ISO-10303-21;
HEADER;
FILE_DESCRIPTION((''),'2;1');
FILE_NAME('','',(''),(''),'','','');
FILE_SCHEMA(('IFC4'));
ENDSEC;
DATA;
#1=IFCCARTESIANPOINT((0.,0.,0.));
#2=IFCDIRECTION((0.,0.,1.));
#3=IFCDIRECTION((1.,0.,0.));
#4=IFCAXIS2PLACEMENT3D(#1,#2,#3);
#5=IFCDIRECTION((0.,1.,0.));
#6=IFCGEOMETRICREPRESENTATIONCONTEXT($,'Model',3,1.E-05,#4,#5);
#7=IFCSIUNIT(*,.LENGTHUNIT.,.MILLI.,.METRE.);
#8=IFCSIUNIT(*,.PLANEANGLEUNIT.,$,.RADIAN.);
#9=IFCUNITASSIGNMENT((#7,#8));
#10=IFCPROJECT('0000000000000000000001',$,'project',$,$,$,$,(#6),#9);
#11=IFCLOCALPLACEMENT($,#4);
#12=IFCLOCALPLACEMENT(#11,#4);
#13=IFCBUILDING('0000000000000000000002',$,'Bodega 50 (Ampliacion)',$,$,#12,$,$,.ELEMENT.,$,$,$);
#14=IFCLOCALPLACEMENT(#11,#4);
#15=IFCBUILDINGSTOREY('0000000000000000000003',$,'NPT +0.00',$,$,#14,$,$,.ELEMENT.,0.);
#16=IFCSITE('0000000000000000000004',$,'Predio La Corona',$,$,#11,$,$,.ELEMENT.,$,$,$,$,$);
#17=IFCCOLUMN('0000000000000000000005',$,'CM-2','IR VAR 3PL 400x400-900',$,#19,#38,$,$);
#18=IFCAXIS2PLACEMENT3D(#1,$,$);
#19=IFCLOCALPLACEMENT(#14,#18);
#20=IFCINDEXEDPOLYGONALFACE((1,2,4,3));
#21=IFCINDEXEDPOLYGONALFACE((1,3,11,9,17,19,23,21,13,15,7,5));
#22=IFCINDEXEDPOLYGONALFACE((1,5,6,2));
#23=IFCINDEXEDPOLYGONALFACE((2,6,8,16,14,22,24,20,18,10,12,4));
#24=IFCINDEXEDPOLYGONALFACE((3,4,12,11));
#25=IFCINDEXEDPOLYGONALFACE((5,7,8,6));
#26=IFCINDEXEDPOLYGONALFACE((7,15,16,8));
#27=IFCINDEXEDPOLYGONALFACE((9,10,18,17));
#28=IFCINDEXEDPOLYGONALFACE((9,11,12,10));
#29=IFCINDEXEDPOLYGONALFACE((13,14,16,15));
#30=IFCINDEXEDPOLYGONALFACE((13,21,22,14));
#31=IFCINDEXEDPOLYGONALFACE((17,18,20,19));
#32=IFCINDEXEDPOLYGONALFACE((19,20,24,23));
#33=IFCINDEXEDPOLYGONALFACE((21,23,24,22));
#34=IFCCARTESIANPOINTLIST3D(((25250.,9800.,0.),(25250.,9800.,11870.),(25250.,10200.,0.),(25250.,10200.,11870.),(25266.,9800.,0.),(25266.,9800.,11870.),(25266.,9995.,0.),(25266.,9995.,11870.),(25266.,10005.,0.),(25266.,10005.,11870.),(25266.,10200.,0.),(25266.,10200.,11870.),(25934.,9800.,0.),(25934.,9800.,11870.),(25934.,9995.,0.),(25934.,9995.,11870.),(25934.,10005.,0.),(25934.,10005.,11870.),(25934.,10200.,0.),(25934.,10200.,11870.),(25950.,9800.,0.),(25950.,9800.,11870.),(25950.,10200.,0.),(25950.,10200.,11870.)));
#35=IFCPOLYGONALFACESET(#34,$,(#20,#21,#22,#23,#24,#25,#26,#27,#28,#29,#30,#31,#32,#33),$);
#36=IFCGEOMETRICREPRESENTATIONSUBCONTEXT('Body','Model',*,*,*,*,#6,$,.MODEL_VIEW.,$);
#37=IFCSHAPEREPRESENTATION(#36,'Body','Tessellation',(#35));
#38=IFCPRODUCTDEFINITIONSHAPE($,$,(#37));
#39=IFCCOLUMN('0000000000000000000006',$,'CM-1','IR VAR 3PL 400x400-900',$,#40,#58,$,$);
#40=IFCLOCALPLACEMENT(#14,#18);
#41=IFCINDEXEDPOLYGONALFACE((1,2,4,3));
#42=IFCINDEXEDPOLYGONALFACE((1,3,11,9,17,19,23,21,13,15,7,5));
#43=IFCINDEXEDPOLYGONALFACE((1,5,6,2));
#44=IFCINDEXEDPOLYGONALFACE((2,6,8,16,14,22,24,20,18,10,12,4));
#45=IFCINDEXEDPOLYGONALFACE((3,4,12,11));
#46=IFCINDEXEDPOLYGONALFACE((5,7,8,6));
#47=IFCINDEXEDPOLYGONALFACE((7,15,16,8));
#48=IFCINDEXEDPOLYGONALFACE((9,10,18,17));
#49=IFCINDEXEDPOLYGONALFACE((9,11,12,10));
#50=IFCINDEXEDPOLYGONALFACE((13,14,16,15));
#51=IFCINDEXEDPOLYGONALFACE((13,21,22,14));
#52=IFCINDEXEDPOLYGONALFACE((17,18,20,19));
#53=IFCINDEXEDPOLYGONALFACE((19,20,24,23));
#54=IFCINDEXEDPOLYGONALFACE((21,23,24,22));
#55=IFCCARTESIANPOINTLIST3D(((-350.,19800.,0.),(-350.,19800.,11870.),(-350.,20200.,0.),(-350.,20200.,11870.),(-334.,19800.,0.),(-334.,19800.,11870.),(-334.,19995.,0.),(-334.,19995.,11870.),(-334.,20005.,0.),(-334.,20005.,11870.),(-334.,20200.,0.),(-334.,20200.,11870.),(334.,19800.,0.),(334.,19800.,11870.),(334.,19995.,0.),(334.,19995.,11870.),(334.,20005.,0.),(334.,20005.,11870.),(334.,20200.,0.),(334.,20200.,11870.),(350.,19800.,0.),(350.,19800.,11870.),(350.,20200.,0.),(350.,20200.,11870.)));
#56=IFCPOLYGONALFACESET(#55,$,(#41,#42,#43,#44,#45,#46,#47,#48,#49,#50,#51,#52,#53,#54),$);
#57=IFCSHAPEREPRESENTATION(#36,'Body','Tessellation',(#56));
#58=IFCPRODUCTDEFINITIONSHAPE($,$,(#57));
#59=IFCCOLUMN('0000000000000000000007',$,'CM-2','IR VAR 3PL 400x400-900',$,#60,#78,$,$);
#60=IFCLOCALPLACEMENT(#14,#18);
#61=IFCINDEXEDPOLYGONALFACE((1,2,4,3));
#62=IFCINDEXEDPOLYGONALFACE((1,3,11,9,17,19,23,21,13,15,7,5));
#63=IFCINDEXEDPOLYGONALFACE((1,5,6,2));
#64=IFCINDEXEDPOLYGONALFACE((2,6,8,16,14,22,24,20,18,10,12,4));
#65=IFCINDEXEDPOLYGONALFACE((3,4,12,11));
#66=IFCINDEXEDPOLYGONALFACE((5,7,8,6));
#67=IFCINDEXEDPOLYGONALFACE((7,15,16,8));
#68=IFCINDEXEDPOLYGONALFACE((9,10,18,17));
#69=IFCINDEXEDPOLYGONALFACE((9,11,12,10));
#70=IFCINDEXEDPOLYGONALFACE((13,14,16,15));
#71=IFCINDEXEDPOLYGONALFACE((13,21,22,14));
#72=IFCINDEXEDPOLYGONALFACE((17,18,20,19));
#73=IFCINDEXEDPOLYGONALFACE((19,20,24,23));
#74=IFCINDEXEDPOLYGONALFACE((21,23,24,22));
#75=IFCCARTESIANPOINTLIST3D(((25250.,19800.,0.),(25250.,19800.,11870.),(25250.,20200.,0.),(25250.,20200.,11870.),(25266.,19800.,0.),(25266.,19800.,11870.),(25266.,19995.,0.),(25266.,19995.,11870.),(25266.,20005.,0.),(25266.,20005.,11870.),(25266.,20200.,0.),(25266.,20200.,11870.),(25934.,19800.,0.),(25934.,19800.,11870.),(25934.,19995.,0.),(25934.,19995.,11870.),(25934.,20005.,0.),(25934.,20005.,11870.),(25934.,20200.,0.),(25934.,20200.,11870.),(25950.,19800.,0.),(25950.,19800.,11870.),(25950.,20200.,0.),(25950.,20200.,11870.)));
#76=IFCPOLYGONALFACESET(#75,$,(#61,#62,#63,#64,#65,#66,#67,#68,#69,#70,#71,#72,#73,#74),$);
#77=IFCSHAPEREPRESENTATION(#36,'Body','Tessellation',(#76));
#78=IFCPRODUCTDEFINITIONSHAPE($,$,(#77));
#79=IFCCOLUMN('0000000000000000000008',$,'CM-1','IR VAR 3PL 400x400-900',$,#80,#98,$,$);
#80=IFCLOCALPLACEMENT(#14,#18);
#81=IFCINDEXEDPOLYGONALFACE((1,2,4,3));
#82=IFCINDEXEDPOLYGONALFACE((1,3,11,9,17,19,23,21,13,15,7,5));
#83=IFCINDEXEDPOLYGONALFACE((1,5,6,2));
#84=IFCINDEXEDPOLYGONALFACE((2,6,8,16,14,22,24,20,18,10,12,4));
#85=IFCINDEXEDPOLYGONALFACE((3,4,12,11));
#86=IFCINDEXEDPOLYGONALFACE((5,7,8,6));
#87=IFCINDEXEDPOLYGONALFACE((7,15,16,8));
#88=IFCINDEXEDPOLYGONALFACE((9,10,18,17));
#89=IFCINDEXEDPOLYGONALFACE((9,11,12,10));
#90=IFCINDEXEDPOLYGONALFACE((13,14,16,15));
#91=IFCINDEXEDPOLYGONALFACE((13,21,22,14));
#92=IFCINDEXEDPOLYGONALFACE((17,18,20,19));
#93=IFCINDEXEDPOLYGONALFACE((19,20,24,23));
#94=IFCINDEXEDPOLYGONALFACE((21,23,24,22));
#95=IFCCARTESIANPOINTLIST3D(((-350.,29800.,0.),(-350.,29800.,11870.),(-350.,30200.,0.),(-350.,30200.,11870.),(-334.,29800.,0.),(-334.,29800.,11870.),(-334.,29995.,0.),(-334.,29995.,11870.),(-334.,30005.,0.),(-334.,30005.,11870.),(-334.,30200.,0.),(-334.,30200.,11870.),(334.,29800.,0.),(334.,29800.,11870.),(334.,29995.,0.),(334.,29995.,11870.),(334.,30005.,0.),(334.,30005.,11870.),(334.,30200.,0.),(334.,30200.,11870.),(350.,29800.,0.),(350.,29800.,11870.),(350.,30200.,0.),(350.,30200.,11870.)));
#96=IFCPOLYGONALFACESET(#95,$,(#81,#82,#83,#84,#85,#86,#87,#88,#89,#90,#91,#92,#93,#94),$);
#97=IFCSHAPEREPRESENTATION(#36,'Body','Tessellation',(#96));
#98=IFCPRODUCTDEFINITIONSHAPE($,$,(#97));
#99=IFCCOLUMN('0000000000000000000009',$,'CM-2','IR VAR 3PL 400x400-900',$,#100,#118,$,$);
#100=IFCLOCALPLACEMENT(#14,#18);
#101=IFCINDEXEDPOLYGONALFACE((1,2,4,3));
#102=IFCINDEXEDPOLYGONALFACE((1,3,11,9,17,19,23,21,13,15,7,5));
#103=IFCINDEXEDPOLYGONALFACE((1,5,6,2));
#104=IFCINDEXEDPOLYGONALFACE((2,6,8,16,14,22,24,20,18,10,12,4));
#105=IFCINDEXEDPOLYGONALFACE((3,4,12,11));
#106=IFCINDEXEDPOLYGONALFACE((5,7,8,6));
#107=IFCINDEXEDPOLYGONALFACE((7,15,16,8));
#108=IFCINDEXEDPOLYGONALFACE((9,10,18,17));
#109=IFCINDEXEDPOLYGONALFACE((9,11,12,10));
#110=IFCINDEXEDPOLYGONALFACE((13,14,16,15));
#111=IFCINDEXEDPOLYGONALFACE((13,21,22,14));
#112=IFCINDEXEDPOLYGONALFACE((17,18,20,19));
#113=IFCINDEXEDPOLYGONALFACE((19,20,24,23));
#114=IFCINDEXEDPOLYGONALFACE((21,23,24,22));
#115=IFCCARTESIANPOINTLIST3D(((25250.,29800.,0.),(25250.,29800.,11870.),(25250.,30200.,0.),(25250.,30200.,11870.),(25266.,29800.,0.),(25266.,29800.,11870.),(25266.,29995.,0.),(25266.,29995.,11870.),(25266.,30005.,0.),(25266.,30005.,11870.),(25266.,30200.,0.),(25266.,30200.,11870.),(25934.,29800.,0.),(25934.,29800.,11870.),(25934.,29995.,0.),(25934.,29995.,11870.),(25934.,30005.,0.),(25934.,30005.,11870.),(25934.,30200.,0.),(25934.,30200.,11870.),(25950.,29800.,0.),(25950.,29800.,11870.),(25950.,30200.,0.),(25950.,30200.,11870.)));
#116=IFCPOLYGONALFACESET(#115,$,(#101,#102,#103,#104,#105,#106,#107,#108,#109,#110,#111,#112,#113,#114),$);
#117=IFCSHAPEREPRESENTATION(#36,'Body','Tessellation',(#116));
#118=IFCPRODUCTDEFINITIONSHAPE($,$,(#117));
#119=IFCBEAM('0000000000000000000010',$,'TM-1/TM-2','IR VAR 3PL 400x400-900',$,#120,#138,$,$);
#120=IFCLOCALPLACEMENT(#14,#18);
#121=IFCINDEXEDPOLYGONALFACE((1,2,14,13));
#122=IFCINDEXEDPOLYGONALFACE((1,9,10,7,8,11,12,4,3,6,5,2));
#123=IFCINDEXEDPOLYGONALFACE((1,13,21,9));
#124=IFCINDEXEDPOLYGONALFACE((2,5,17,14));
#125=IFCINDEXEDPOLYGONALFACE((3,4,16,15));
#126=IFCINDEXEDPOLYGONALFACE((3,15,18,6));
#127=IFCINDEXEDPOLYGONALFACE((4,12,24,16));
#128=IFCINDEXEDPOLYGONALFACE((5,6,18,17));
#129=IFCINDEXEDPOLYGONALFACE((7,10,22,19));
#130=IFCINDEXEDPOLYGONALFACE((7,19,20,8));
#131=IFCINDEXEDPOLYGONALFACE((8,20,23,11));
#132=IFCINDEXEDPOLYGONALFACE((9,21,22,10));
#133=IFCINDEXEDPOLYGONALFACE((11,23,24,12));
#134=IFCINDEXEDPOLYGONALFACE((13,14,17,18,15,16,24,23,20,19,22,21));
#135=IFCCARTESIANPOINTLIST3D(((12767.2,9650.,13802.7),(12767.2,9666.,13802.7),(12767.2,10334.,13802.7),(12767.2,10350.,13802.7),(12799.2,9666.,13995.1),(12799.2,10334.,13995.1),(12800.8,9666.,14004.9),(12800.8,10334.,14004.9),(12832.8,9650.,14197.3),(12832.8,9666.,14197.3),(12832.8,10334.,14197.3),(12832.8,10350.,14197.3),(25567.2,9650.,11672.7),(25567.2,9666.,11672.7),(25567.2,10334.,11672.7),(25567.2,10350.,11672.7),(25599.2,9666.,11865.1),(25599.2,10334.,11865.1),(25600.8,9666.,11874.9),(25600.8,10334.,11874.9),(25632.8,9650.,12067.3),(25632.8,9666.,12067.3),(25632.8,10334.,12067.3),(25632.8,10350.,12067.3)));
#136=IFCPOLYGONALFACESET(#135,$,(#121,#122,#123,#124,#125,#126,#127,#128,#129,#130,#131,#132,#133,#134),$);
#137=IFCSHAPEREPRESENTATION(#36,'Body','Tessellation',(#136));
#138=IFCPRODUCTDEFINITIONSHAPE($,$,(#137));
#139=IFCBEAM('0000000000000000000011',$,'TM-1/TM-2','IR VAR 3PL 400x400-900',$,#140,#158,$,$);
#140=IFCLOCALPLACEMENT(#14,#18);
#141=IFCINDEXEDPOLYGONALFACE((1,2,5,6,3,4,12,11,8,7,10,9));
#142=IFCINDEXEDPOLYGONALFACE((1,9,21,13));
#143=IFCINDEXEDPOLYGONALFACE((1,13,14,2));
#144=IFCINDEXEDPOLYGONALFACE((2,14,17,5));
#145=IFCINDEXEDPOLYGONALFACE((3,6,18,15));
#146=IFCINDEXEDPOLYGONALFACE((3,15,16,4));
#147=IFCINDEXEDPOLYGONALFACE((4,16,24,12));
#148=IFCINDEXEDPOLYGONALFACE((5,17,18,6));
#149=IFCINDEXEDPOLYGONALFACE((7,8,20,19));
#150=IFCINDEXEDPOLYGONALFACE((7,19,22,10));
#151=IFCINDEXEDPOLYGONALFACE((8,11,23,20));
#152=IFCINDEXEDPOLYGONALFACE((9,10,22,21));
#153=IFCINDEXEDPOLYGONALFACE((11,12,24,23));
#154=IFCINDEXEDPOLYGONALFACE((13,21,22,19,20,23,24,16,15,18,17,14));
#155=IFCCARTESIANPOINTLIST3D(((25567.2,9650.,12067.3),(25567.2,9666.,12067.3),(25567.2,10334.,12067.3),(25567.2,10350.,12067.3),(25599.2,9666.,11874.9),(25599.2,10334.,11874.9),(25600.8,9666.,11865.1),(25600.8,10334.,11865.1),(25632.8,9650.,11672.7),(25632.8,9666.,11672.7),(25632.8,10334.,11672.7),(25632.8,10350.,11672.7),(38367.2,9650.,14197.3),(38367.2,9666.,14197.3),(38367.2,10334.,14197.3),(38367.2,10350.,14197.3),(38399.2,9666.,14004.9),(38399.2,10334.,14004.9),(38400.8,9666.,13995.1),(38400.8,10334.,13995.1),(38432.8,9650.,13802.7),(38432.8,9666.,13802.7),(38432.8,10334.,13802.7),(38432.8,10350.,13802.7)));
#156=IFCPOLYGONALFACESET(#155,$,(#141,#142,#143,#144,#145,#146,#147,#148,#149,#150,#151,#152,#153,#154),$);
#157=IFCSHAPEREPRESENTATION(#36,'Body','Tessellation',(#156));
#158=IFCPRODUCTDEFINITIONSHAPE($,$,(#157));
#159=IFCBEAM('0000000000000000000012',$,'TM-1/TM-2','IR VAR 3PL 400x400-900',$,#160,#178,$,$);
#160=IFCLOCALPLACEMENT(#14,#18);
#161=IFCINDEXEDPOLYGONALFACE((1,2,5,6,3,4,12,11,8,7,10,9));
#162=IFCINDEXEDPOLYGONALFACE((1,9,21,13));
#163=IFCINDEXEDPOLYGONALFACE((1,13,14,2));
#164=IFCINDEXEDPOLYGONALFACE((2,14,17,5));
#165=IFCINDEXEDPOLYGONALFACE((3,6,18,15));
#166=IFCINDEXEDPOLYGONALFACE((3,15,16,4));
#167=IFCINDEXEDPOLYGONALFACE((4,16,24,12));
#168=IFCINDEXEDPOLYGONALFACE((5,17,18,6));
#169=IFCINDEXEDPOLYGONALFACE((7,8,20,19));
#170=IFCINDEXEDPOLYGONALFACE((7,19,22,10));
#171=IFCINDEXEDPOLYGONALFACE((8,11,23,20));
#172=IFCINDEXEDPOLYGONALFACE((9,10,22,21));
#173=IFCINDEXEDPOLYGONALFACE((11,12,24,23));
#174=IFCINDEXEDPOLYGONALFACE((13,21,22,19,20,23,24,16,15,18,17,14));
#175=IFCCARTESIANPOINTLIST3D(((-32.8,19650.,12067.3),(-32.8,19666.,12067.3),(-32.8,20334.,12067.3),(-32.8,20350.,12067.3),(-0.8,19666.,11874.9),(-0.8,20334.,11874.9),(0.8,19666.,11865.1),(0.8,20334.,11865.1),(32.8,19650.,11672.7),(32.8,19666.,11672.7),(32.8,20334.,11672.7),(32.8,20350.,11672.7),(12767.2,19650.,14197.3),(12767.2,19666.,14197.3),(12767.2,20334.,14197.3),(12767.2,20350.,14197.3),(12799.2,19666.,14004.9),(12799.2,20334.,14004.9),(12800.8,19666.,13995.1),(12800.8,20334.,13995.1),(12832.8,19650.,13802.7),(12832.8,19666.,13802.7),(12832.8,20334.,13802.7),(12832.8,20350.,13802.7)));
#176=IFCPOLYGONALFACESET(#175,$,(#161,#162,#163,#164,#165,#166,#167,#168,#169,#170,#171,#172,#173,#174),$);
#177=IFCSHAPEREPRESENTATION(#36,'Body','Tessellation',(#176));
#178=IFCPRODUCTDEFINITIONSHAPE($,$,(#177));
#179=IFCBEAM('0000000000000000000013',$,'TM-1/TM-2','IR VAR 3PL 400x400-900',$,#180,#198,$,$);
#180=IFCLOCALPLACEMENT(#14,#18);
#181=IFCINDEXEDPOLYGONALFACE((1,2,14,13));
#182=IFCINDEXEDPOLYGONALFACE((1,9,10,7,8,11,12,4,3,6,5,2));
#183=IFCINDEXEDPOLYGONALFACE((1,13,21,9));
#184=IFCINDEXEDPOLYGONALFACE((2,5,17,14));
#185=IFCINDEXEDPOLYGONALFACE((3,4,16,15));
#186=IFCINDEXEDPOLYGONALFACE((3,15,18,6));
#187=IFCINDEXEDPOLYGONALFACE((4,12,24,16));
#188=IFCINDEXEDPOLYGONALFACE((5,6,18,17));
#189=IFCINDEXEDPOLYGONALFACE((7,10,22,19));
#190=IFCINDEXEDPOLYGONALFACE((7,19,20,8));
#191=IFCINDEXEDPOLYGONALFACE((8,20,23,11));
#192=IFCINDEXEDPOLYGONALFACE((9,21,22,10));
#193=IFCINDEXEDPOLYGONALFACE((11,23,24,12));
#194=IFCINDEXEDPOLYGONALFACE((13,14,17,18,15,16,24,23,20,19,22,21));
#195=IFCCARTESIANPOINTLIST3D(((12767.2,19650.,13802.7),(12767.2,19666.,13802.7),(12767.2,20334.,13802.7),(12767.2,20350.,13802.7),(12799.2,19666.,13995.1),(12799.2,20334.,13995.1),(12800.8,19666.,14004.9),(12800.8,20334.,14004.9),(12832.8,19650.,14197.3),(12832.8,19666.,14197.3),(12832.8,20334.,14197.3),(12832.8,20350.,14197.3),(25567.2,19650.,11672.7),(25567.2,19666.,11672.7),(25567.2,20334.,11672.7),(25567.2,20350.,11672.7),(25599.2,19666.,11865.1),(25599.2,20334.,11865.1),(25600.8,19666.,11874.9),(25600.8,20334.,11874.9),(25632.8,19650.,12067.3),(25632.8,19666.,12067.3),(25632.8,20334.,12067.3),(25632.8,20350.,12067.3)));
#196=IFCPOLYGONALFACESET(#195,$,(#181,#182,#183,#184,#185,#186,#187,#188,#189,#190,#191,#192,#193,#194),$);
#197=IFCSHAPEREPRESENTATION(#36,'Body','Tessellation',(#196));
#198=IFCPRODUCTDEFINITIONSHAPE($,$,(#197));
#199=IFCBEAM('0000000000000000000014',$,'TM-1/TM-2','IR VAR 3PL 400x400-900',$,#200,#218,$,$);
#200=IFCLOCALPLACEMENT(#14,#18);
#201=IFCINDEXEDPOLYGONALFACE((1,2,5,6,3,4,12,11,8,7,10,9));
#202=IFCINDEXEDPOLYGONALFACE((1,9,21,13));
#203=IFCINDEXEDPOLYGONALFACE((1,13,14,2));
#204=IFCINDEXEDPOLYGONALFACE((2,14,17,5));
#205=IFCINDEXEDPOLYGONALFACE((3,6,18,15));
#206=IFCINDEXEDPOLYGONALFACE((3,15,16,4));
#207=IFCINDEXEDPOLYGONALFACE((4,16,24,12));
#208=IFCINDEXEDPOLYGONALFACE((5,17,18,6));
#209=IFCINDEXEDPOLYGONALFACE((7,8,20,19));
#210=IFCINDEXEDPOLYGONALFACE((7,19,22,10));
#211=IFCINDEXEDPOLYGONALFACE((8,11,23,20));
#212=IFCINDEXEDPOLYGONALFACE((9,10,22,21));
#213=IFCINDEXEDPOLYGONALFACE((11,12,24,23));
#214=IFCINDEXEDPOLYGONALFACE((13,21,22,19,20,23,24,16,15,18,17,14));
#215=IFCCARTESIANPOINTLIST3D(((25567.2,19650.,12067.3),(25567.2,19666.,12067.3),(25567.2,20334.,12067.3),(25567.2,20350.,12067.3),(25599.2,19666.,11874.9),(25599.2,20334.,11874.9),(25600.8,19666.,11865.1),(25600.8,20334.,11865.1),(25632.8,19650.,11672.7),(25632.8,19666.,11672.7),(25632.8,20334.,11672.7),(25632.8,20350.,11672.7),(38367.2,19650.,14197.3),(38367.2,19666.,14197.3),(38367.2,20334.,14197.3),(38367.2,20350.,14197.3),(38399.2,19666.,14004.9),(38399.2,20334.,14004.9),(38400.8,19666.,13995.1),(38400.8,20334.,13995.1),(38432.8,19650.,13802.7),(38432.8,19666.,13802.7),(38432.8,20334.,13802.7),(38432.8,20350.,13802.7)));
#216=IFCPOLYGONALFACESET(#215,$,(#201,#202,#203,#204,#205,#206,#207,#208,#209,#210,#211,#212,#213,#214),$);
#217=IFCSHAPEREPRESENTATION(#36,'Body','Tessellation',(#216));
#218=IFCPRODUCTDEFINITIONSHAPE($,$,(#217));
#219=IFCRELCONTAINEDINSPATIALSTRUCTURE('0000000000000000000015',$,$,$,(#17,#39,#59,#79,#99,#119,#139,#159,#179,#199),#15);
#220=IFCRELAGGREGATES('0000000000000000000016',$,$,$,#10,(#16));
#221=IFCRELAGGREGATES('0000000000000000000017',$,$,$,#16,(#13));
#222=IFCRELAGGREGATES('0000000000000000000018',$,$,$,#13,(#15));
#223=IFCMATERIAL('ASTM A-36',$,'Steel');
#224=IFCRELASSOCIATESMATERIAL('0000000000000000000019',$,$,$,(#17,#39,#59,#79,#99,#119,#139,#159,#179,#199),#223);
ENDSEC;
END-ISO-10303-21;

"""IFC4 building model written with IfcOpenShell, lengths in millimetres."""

from ifc_helpers import new_model, si_unit, direction, frame, origin_with_axes, origin_2d, place, context, subcontext, project, spatial, i_section, extrude, material, element, save


model = new_model("IFC4")

# Units and contexts
model_context = context("Model", 3, precision=1e-05, world=origin_with_axes(), true_north=direction((0.0, 1.0, 0.0)))
body_context = subcontext(model_context, "Body", "Model", "MODEL_VIEW")
ifc_project = project(units=[si_unit("LENGTHUNIT", "METRE", prefix="MILLI"), si_unit("PLANEANGLEUNIT", "RADIAN")], contexts=[model_context])

# Site, building, storey
site_placement = place(None, origin_with_axes())
site = spatial("IfcSite", under=ifc_project, at=site_placement, Name="Predio La Corona", CompositionType="ELEMENT")
building_placement = place(site_placement, origin_with_axes())
building = spatial("IfcBuilding", under=site, at=building_placement, Name="Bodega 50 (Ampliacion)", CompositionType="ELEMENT")
storey_placement = place(site_placement, origin_with_axes())
storey = spatial("IfcBuildingStorey", under=building, at=storey_placement, Name="NPT +0.00", CompositionType="ELEMENT", Elevation=0.0)

# Columns
ifc_material = material(Name="ASTM A-36", Category="Steel")
for number, where, z_axis, x_axis, name in (
    (1, (25600.0, 10000.0, 0.0), (0.0, 0.0, 1.0), (0.0, -1.0, 0.0), "CM-2"),
    (2, (0.0, 20000.0, 0.0), (0.0, 0.0, 1.0), (0.0, -1.0, 0.0), "CM-1"),
    (3, (25600.0, 20000.0, 0.0), (0.0, 0.0, 1.0), (0.0, -1.0, 0.0), "CM-2"),
    (4, (0.0, 30000.0, 0.0), (0.0, 0.0, 1.0), (0.0, -1.0, 0.0), "CM-1"),
    (5, (25600.0, 30000.0, 0.0), (0.0, 0.0, 1.0), (0.0, -1.0, 0.0), "CM-2"),
):
    element("IfcColumn", number, at=place(storey_placement, frame(where, z_axis=z_axis, x_axis=x_axis)), inside=storey, material=ifc_material, Name=name, Description="IR VAR 3PL 400x400-900", context=body_context, shape_type="SweptSolid", body=[
        extrude(i_section(OverallWidth=400.0, OverallDepth=700.0, WebThickness=10.0, FlangeThickness=16.0, at=origin_2d()), origin_with_axes(), (0.0, 0.0, 1.0), 11870.0),
    ])

# Beams
for number, where, z_axis, x_axis, name in (
    (6, (12800.0, 10000.0, 14000.0), (0.986436, 0.0, -0.164149), (-0.164149, 0.0, -0.986436), "TM-1/TM-2"),
    (7, (25600.0, 10000.0, 11870.0), (0.986436, 0.0, 0.164149), (0.164149, 0.0, -0.986436), "TM-1/TM-2"),
    (8, (0.0, 20000.0, 11870.0), (0.986436, 0.0, 0.164149), (0.164149, 0.0, -0.986436), "TM-1/TM-2"),
    (9, (12800.0, 20000.0, 14000.0), (0.986436, 0.0, -0.164149), (-0.164149, 0.0, -0.986436), "TM-1/TM-2"),
    (10, (25600.0, 20000.0, 11870.0), (0.986436, 0.0, 0.164149), (0.164149, 0.0, -0.986436), "TM-1/TM-2"),
):
    element("IfcBeam", number, at=place(storey_placement, frame(where, z_axis=z_axis, x_axis=x_axis)), inside=storey, material=ifc_material, Name=name, Description="IR VAR 3PL 400x400-900", context=body_context, shape_type="SweptSolid", body=[
        extrude(i_section(OverallWidth=400.0, OverallDepth=700.0, WebThickness=10.0, FlangeThickness=16.0, at=origin_2d()), origin_with_axes(), (0.0, 0.0, 1.0), 12976.0),
    ])

save(model, "model.ifc")
